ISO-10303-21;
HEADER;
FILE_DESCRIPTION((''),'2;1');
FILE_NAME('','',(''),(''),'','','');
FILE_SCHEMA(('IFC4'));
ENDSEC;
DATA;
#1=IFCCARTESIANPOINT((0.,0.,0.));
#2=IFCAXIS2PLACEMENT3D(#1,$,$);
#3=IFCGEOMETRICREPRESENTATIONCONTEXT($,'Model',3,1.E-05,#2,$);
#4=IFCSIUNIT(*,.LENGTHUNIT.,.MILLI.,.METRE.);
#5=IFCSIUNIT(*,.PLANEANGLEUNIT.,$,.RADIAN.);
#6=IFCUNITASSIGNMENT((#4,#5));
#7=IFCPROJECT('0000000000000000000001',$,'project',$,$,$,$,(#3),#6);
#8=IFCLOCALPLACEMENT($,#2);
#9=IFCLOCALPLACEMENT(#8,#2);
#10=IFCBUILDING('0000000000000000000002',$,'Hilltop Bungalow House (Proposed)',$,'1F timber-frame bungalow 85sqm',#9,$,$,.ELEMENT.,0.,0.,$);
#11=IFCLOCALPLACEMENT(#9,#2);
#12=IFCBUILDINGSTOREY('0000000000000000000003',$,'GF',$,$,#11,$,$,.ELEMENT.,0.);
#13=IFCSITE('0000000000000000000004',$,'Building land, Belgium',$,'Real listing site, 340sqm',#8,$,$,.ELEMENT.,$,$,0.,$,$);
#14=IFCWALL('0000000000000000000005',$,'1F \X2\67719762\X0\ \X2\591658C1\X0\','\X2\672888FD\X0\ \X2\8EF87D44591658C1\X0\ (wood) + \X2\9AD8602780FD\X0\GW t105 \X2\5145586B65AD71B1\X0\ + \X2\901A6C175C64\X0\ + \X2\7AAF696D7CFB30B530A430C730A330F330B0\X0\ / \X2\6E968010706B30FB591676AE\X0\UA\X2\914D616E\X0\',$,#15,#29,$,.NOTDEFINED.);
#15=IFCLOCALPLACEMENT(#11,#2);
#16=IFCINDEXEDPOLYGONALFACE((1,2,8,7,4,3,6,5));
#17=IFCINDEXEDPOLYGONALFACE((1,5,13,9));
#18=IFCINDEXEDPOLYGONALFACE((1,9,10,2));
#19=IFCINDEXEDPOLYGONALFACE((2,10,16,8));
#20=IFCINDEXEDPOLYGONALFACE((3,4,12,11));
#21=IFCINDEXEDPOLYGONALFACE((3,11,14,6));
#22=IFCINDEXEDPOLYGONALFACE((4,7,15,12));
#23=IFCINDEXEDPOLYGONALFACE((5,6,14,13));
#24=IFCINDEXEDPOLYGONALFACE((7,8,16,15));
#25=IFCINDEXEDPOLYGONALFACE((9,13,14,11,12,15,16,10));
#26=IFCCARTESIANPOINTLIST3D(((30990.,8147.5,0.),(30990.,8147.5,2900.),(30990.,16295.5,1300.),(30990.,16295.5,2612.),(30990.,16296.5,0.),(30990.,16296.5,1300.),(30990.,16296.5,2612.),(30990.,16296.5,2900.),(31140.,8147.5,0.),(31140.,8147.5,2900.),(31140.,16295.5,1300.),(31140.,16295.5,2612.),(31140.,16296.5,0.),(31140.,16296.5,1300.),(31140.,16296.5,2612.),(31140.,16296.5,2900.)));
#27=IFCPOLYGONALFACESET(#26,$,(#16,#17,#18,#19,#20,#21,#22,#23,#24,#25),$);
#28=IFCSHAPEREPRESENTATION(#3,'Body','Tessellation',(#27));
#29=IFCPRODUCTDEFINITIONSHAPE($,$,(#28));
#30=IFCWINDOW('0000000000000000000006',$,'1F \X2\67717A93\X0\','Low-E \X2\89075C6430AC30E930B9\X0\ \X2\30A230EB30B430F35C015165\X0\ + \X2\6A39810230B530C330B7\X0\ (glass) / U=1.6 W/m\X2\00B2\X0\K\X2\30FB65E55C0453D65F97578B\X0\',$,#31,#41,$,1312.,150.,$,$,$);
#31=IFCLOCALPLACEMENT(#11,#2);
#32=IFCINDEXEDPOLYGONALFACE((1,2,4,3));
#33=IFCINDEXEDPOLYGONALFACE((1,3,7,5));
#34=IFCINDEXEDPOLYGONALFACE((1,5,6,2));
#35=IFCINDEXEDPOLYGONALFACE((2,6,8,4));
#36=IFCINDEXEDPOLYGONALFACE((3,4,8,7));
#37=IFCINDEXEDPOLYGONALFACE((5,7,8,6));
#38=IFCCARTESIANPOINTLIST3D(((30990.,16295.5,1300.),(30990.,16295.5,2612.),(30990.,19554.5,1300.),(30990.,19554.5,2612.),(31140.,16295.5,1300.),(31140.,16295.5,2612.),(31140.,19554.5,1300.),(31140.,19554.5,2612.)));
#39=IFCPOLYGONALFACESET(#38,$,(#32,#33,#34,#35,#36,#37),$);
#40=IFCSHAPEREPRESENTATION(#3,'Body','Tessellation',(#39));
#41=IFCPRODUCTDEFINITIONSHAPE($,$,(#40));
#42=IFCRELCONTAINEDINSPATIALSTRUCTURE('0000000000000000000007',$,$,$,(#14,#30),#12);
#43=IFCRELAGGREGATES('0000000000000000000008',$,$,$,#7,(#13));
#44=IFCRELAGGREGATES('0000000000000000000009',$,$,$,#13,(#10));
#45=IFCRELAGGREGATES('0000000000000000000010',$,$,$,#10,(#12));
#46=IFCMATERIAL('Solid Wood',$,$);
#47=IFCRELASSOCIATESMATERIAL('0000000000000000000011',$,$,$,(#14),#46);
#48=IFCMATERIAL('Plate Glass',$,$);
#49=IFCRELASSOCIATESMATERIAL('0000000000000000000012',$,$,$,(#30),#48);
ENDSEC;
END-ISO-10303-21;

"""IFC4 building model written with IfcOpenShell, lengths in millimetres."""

from ifc_helpers import new_model, si_unit, frame, frame_2d, origin, place, context, project, spatial, rectangle, extrude, material, element, fill, save


model = new_model("IFC4")

# Units and contexts
model_context = context("Model", 3, precision=1e-05, world=origin())
ifc_project = project(units=[si_unit("LENGTHUNIT", "METRE", prefix="MILLI"), si_unit("PLANEANGLEUNIT", "RADIAN")], contexts=[model_context])

# Site, building, storey
site_placement = place(None, origin())
site = spatial("IfcSite", under=ifc_project, at=site_placement, Name="Building land, Belgium", ObjectType="Real listing site, 340sqm", CompositionType="ELEMENT", RefElevation=0.0)
building_placement = place(site_placement, origin())
building = spatial("IfcBuilding", under=site, at=building_placement, Name="Hilltop Bungalow House (Proposed)", ObjectType="1F timber-frame bungalow 85sqm", CompositionType="ELEMENT", ElevationOfRefHeight=0.0, ElevationOfTerrain=0.0)
storey_placement = place(building_placement, origin())
storey = spatial("IfcBuildingStorey", under=building, at=storey_placement, Name="GF", CompositionType="ELEMENT", Elevation=0.0)

# Shared definitions
ifc_material_1 = material(Name="Solid Wood")

# Wall, opening, window
wall_1_placement = place(storey_placement, frame((15495.0, 4074.0, 0.0)))
wall_1 = element("IfcWall", 1, at=wall_1_placement, inside=storey, material=ifc_material_1, Name="1F 東面 外壁", Description="木製 軸組外壁 (wood) + 高性能GW t105 充填断熱 + 通気層 + 窯業系サイディング / 準耐火・外皮UA配慮", PredefinedType="NOTDEFINED", context=model_context, shape_type="SweptSolid", body=[
    extrude(rectangle(XDim=150.0, YDim=8149.0, at=frame_2d((75.0, 4074.0))), frame((15495.0, 4074.0, 0.0)), (0.0, 0.0, 1.0), 2900.0),
])
opening_placement = place(storey_placement, frame((15495.0, 8148.0, 650.0)))
opening = element("IfcOpeningElement", 2, at=opening_placement, cuts=wall_1, PredefinedType="NOTDEFINED", context=model_context, shape_type="SweptSolid", body=[
    extrude(rectangle(XDim=150.0, YDim=3259.0, at=frame_2d((75.0, 1629.0))), frame((15495.0, 8148.0, 650.0)), (0.0, 0.0, 1.0), 1312.0),
])
ifc_material_2 = material(Name="Plate Glass")
window_placement = place(storey_placement, frame((15495.0, 8148.0, 650.0)))
window = element("IfcWindow", 3, at=window_placement, inside=storey, material=ifc_material_2, Name="1F 東窓", Description="Low-E 複層ガラス アルゴン封入 + 樹脂サッシ (glass) / U=1.6 W/m²K・日射取得型", OverallHeight=1312.0, OverallWidth=150.0, context=model_context, shape_type="SweptSolid", body=[
    extrude(rectangle(XDim=150.0, YDim=3259.0, at=frame_2d((75.0, 1629.0))), frame((15495.0, 8148.0, 650.0)), (0.0, 0.0, 1.0), 1312.0),
])
fill(opening, window)

save(model, "model.ifc")
